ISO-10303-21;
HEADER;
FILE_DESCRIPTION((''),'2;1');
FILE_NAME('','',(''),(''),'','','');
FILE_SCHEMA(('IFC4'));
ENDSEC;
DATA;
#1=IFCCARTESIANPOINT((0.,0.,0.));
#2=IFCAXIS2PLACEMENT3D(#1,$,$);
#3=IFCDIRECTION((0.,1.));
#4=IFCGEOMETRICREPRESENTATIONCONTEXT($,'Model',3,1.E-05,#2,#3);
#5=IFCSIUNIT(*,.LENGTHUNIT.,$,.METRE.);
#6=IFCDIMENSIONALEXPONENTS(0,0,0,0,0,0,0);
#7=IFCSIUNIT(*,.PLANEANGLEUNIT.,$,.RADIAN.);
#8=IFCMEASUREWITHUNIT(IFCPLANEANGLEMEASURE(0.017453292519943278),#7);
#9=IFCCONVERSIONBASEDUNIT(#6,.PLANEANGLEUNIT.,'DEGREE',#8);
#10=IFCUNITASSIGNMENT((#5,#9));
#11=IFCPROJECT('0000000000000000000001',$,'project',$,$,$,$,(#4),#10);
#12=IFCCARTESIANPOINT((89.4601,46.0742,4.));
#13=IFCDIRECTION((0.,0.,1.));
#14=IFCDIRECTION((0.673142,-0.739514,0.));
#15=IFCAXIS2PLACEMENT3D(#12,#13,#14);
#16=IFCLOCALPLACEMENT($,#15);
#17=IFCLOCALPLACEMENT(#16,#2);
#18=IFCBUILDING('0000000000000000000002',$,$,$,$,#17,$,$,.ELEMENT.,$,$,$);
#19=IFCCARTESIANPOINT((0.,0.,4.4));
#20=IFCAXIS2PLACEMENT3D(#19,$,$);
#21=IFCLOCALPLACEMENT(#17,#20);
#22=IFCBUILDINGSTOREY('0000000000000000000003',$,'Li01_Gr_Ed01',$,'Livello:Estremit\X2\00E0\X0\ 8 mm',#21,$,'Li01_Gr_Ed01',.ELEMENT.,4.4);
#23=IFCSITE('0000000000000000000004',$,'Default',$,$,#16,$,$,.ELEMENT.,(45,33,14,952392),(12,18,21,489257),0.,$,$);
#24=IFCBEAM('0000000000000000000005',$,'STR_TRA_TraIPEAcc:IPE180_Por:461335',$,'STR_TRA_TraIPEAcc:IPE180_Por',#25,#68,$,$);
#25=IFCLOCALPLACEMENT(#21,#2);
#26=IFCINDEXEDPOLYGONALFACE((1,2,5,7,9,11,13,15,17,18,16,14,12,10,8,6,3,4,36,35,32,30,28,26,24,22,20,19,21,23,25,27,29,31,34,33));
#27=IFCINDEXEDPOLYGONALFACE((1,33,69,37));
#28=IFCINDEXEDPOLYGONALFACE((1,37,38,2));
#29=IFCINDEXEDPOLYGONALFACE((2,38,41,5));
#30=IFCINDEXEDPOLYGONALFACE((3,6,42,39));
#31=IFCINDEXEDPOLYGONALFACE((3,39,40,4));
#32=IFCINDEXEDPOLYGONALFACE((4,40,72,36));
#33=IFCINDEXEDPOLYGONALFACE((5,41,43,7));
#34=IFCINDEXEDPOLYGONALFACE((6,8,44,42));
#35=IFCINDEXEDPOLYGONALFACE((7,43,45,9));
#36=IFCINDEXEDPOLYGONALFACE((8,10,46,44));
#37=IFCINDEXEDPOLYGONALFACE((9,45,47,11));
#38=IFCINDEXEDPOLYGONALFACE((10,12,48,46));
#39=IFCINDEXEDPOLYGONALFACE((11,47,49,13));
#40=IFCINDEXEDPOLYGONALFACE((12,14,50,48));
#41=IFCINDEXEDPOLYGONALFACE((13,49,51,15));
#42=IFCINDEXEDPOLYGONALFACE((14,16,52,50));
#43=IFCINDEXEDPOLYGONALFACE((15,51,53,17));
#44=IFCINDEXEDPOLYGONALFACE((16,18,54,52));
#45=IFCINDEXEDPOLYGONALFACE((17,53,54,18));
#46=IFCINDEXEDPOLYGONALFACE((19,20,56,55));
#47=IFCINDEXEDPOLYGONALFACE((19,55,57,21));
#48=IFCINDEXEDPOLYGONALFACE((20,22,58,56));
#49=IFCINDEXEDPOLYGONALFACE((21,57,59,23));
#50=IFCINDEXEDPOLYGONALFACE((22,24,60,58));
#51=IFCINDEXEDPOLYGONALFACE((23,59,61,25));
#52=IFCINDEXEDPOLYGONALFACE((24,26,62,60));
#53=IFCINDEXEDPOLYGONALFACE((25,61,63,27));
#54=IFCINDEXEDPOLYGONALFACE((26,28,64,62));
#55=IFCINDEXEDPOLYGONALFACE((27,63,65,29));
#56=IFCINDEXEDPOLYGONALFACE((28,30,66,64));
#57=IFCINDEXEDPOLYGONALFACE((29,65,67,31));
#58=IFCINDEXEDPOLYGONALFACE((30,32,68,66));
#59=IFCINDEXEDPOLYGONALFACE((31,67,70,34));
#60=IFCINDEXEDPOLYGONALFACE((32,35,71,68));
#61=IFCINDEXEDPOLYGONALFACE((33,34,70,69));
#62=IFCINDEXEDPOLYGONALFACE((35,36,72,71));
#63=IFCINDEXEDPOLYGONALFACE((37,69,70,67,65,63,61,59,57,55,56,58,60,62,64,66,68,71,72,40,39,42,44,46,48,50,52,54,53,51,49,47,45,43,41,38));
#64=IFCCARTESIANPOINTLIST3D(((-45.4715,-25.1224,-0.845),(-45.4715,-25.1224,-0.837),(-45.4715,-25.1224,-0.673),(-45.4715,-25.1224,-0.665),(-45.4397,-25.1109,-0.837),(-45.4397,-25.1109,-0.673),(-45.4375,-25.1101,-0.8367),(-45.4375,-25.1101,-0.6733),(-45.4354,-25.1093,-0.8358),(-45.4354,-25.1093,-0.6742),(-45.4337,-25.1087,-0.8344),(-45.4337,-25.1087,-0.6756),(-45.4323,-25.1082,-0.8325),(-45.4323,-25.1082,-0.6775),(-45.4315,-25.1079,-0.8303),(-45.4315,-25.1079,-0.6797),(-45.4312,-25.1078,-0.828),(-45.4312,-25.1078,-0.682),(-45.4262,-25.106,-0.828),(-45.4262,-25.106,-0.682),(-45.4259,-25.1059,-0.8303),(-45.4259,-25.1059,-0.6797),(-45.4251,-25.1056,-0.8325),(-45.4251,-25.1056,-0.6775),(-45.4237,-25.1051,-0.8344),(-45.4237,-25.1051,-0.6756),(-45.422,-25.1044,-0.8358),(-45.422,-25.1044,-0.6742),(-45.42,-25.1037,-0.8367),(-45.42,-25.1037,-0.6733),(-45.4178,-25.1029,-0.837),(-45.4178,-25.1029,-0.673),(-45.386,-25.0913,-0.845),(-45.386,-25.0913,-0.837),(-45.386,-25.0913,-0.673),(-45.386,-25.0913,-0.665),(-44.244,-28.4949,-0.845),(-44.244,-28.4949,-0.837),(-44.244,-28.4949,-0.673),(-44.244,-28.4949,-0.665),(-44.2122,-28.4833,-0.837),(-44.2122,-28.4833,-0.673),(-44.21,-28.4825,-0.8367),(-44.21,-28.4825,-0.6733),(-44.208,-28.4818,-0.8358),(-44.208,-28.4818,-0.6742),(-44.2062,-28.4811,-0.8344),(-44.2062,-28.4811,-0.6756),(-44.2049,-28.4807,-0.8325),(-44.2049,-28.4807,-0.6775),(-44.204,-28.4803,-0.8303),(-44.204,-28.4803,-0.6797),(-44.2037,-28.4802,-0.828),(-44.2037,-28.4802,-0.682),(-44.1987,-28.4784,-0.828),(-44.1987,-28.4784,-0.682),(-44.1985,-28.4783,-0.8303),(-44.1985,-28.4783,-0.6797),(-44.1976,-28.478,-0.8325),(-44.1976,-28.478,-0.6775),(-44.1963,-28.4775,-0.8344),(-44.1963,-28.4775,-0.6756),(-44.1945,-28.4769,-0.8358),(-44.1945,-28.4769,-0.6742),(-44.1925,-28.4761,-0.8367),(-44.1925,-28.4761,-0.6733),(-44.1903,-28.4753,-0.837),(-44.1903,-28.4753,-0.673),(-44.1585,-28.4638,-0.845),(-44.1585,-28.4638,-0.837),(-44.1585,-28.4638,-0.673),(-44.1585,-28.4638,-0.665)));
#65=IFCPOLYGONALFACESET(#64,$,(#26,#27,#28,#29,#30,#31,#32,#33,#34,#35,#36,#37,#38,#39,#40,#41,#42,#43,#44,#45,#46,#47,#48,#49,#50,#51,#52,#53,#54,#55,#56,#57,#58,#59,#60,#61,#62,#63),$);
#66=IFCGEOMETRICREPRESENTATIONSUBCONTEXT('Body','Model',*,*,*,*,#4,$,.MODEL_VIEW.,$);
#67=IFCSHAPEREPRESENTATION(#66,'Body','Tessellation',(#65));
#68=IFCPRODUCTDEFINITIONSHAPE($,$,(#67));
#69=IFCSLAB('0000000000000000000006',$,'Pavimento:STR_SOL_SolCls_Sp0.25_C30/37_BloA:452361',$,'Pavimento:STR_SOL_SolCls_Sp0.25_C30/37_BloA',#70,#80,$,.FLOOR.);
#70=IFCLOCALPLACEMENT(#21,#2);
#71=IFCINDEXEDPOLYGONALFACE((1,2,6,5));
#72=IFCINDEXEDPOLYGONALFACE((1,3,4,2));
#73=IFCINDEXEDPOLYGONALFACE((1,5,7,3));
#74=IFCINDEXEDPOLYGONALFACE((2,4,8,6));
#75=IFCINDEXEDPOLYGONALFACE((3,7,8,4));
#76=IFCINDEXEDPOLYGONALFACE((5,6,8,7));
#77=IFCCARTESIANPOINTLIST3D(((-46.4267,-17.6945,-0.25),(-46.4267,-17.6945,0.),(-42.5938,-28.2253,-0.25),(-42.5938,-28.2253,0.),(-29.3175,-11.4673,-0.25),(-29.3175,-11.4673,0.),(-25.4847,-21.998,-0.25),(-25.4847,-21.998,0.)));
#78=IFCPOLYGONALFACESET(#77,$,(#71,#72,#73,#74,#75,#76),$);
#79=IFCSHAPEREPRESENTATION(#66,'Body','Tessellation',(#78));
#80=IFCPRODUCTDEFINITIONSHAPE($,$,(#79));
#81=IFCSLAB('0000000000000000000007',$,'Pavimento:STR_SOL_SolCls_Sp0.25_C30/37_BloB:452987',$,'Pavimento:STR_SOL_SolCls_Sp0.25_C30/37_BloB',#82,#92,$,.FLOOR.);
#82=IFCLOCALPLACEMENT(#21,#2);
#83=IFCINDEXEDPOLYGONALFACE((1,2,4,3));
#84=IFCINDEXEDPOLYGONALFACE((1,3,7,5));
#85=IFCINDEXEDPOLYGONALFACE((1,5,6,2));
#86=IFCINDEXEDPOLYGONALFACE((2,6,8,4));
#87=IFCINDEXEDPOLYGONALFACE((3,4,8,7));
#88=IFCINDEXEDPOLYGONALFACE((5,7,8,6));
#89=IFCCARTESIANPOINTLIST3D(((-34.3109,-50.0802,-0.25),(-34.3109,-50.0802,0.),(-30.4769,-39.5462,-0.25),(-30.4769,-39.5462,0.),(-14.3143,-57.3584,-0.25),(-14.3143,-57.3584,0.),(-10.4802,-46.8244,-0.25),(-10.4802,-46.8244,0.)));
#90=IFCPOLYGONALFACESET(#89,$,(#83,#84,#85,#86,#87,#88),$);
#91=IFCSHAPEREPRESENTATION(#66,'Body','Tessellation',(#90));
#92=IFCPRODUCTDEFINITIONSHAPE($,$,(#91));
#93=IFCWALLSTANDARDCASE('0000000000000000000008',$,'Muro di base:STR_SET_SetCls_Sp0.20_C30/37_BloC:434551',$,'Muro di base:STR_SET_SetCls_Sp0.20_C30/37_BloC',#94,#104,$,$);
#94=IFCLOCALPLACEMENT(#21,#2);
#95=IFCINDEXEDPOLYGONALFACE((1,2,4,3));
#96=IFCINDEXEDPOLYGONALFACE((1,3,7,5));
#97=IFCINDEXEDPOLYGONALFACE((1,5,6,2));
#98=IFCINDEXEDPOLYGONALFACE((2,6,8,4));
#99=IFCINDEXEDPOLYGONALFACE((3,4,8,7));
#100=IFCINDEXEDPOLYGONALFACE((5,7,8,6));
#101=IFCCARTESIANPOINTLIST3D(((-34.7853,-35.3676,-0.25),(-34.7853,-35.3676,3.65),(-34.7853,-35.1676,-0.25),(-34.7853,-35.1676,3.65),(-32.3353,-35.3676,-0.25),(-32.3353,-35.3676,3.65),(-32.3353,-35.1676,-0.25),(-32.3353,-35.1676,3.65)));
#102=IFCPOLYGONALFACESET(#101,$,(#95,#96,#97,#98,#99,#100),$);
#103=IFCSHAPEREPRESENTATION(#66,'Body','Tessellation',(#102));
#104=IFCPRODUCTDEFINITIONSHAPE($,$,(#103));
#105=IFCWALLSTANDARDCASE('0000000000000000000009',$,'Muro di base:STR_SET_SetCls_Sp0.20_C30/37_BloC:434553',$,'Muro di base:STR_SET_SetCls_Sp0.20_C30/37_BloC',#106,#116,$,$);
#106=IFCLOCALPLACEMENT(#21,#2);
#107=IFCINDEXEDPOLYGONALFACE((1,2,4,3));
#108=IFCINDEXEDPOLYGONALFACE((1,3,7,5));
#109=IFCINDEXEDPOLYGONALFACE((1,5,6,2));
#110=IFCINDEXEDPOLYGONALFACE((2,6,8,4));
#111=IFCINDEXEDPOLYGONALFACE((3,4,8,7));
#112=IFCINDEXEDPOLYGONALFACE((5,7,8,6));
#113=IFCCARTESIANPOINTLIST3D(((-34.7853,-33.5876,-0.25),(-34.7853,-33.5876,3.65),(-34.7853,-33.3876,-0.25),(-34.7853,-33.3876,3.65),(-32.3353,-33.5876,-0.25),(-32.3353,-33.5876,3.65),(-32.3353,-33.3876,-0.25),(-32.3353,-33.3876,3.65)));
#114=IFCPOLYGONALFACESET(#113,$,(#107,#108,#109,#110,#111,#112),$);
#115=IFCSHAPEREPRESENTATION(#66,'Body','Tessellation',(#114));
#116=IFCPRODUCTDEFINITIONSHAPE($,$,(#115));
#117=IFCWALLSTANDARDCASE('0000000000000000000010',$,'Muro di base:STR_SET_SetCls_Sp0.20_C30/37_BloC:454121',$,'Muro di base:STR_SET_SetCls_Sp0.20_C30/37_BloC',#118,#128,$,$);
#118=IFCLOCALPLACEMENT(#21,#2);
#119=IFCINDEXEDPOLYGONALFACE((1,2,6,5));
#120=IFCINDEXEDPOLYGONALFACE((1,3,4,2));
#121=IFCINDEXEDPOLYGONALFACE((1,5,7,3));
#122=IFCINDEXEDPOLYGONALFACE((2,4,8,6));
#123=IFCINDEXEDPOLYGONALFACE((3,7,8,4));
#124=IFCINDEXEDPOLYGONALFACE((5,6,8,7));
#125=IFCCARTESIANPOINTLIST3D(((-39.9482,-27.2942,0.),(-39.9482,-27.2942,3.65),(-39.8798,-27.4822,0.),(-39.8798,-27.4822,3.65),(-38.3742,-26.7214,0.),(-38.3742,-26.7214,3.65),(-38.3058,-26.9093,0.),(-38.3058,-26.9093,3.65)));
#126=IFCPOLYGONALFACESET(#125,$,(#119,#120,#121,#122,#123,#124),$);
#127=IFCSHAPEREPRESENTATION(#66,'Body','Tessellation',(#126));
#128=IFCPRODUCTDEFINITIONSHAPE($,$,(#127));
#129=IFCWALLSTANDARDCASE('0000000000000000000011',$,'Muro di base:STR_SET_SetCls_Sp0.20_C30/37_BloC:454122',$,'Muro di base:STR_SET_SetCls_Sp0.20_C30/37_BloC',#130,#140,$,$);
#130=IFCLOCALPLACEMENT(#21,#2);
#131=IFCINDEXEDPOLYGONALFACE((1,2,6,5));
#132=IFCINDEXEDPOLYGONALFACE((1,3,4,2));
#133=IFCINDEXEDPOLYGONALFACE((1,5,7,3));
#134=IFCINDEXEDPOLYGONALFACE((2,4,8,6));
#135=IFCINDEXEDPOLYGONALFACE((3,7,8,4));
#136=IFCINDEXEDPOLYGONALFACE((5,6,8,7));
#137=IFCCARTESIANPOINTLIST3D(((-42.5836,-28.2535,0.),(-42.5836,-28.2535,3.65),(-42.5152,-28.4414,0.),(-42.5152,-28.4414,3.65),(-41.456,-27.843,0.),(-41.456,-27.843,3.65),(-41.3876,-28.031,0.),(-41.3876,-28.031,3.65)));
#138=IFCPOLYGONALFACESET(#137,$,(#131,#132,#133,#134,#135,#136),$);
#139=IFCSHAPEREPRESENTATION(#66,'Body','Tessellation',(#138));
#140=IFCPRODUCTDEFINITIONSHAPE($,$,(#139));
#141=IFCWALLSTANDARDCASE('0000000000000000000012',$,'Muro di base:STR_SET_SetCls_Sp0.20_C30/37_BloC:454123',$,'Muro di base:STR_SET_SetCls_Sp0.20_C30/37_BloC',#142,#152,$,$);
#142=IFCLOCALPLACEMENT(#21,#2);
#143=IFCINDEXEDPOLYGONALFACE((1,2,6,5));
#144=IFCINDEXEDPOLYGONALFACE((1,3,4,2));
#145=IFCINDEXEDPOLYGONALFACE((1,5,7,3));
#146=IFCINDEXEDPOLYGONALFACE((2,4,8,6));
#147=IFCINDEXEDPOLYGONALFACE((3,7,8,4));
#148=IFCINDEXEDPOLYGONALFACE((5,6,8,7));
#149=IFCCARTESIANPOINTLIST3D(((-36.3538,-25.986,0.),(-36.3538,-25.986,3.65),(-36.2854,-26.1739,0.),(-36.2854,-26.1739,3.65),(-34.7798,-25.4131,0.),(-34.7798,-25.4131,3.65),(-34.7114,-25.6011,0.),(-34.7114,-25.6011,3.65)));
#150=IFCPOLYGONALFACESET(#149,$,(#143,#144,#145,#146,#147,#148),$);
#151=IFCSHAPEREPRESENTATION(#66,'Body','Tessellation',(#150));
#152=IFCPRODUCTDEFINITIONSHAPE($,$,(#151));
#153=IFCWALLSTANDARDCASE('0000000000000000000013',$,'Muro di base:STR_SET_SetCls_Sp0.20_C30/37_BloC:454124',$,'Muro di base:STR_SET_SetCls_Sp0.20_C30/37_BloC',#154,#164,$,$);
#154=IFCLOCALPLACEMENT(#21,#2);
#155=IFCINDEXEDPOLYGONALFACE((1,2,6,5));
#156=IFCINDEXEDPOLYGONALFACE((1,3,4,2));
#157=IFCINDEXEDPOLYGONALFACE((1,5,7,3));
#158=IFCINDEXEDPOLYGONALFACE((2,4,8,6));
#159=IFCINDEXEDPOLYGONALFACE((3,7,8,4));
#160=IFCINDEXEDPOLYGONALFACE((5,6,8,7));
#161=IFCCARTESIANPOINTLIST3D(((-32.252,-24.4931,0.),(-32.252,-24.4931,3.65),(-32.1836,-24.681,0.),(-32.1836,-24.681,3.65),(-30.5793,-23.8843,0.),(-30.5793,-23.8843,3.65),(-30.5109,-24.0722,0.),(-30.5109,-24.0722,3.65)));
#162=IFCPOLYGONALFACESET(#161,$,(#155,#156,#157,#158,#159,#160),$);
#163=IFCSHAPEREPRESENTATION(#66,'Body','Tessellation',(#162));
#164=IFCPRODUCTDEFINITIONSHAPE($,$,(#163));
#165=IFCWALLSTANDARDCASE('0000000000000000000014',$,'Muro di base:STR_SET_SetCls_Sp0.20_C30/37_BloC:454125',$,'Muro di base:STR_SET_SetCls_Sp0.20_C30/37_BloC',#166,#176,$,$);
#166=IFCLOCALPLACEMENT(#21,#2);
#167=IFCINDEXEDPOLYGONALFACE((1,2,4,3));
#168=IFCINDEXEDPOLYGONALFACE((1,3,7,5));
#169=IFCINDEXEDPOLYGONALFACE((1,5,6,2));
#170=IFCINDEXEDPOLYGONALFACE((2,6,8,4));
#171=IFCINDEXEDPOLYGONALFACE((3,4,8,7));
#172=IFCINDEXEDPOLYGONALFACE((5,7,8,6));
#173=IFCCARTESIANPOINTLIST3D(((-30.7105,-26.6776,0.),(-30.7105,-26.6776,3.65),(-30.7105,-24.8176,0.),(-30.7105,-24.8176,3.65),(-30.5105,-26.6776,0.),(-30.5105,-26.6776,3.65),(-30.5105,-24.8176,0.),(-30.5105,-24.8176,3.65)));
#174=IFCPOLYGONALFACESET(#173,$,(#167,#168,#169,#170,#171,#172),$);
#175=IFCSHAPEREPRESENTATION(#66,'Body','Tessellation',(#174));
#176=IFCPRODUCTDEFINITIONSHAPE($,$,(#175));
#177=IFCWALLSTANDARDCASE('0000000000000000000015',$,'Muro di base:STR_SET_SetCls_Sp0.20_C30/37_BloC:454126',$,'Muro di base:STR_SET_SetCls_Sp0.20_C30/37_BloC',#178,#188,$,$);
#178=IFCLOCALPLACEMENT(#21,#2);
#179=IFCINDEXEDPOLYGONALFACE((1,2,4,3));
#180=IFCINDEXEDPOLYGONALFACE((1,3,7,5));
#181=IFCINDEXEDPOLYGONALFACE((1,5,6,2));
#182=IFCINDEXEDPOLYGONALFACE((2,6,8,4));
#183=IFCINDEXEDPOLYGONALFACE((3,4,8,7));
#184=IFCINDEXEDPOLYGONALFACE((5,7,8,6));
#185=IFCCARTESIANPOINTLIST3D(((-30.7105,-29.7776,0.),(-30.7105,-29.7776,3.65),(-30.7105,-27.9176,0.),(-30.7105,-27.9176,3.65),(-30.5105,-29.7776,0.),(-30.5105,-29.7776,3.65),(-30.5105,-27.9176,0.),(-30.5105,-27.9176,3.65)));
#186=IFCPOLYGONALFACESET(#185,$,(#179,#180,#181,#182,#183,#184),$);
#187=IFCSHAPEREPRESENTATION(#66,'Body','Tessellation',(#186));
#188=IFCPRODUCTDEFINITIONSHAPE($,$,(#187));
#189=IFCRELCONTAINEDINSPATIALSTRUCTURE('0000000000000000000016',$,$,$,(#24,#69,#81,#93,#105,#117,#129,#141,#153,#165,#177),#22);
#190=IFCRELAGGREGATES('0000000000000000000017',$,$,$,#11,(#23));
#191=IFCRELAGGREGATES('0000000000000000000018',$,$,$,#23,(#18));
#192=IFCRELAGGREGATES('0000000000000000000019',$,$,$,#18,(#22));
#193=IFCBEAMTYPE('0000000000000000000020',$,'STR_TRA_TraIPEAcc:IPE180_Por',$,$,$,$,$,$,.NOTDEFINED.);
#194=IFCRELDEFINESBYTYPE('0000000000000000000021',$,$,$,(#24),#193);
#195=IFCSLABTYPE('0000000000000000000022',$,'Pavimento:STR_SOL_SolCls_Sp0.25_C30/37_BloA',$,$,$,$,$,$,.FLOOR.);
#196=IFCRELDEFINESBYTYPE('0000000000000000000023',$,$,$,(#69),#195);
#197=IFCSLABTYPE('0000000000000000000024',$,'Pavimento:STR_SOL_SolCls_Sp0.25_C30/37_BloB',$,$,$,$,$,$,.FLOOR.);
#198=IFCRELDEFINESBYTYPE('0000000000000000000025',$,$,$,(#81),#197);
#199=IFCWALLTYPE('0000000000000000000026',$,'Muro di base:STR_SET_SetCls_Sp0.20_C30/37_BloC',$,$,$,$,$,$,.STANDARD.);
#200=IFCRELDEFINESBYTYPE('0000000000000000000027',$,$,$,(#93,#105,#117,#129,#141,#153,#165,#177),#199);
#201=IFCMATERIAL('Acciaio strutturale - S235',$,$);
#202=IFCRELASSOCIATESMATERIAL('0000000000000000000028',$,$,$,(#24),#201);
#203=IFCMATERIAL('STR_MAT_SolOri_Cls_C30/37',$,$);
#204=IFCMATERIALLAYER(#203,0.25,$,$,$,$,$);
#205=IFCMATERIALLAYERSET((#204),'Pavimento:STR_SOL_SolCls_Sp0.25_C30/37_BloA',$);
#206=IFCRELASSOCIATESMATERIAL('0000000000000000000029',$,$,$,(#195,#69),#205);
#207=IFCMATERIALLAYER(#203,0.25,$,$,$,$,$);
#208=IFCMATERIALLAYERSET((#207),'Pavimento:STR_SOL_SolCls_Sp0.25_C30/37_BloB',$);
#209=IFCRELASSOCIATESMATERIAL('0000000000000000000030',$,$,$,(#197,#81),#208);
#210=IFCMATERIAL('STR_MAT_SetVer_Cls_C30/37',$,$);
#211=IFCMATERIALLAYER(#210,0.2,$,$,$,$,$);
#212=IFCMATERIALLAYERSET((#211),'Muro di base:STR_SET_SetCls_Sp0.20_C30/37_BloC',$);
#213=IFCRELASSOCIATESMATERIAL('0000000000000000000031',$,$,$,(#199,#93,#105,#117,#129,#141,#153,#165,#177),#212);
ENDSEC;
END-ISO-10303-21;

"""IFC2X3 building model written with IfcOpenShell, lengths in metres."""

from ifc_helpers import new_model, entity, si_unit, converted_unit, direction, frame, frame_2d, origin, place, context, subcontext, project, spatial, polyline, rectangle, i_section, outline, extrude, material, layer, layer_set, layer_usage, type_object, element, save


model = new_model("IFC2X3")

# Units and contexts
model_context = context("Model", 3, precision=1e-05, world=origin(), true_north=direction((0.0, 1.0)))
body_context = subcontext(model_context, "Body", "Model", "MODEL_VIEW")
ifc_project = project(units=[si_unit("LENGTHUNIT", "METRE"), converted_unit("PLANEANGLEUNIT", "DEGREE", entity("IfcPlaneAngleMeasure", 0.017453292519943278), si_unit("PLANEANGLEUNIT", "RADIAN"), dimensions=[0, 0, 0, 0, 0, 0, 0])], contexts=[model_context])

# Site, building, storey
site_placement = place(None, frame((89.4601, 46.0742, 4.0), z_axis=(0.0, 0.0, 1.0), x_axis=(0.673142, -0.739514, 0.0)))
site = spatial("IfcSite", under=ifc_project, at=site_placement, Name="Default", CompositionType="ELEMENT", RefLatitude=(45, 33, 14, 952392), RefLongitude=(12, 18, 21, 489257), RefElevation=0.0)
building_placement = place(site_placement, origin())
building = spatial("IfcBuilding", under=site, at=building_placement, CompositionType="ELEMENT")
storey_placement = place(building_placement, frame((0.0, 0.0, 4.4)))
storey = spatial("IfcBuildingStorey", under=building, at=storey_placement, Name="Li01_Gr_Ed01", ObjectType="Livello:Estremità 8 mm", LongName="Li01_Gr_Ed01", CompositionType="ELEMENT", Elevation=4.4)

# Beam
ifc_material_1 = material(Name="Acciaio strutturale - S235")
beam_type = type_object("IfcBeamType", Name="STR_TRA_TraIPEAcc:IPE180_Por", PredefinedType="NOTDEFINED")
beam_1_placement = place(storey_placement, frame((-45.4812, -24.9627, -0.665), z_axis=(0.0, 0.0, 1.0), x_axis=(0.34202, -0.939693, 0.0)))
element("IfcBeam", 1, at=beam_1_placement, inside=storey, type_object=beam_type, material=ifc_material_1, Name="STR_TRA_TraIPEAcc:IPE180_Por:461335", ObjectType="STR_TRA_TraIPEAcc:IPE180_Por", context=body_context, shape_type="SweptSolid", body=[
    extrude(i_section(OverallWidth=0.091, OverallDepth=0.18, WebThickness=0.0053, FlangeThickness=0.008, FilletRadius=0.009, at=frame_2d((0.0, 0.0), x_axis=(0.0, 1.0))), frame((0.1534, 0.0, -0.09), z_axis=(1.0, 0.0, 0.0), x_axis=(0.0, 0.0, -1.0)), (0.0, 0.0, 1.0), 3.5889),
])

# Slabs
ifc_material_2 = material(Name="STR_MAT_SolOri_Cls_C30/37")
ifc_layer_1 = layer(ifc_material_2, 0.25)
ifc_layer_set_1 = layer_set([ifc_layer_1], Name="Pavimento:STR_SOL_SolCls_Sp0.25_C30/37_BloA")
ifc_layer_usage_1 = layer_usage(ifc_layer_set_1, "AXIS3", "POSITIVE", 0.0)
slab_type_1 = type_object("IfcSlabType", Name="Pavimento:STR_SOL_SolCls_Sp0.25_C30/37_BloA", PredefinedType="FLOOR", material=ifc_layer_set_1)
slab_1_placement = place(storey_placement, origin())
element("IfcSlab", 2, at=slab_1_placement, inside=storey, type_object=slab_type_1, material=ifc_layer_usage_1, Name="Pavimento:STR_SOL_SolCls_Sp0.25_C30/37_BloA:452361", ObjectType="Pavimento:STR_SOL_SolCls_Sp0.25_C30/37_BloA", PredefinedType="FLOOR", context=body_context, shape_type="SweptSolid", body=[
    extrude(rectangle(XDim=18.2072, YDim=11.2066, at=frame_2d((0.0, 0.0), x_axis=(1.0, 0.0))), frame((-35.9557, -19.8463, 0.0), z_axis=(0.0, 0.0, -1.0), x_axis=(0.939693, 0.34202, 0.0)), (0.0, 0.0, 1.0), 0.25),
])
ifc_layer_2 = layer(ifc_material_2, 0.25)
ifc_layer_set_2 = layer_set([ifc_layer_2], Name="Pavimento:STR_SOL_SolCls_Sp0.25_C30/37_BloB")
ifc_layer_usage_2 = layer_usage(ifc_layer_set_2, "AXIS3", "POSITIVE", 0.0)
slab_type_2 = type_object("IfcSlabType", Name="Pavimento:STR_SOL_SolCls_Sp0.25_C30/37_BloB", PredefinedType="FLOOR", material=ifc_layer_set_2)
slab_2_placement = place(storey_placement, origin())
element("IfcSlab", 3, at=slab_2_placement, inside=storey, type_object=slab_type_2, material=ifc_layer_usage_2, Name="Pavimento:STR_SOL_SolCls_Sp0.25_C30/37_BloB:452987", ObjectType="Pavimento:STR_SOL_SolCls_Sp0.25_C30/37_BloB", PredefinedType="FLOOR", context=body_context, shape_type="SweptSolid", body=[
    extrude(outline(polyline([(-10.64, -5.605), (10.64, -5.605), (10.64, 5.605), (-10.64, 5.605), (-10.64, -5.605)])), frame((-22.3956, -48.4523, 0.0), z_axis=(0.0, 0.0, -1.0), x_axis=(0.939693, -0.34202, 0.0)), (0.0, 0.0, 1.0), 0.25),
])

# Walls
ifc_material_3 = material(Name="STR_MAT_SetVer_Cls_C30/37")
ifc_layer_3 = layer(ifc_material_3, 0.2)
ifc_layer_set_3 = layer_set([ifc_layer_3], Name="Muro di base:STR_SET_SetCls_Sp0.20_C30/37_BloC")
ifc_layer_usage_3 = layer_usage(ifc_layer_set_3, "AXIS2", "NEGATIVE", 0.1)
wall_type = type_object("IfcWallType", Name="Muro di base:STR_SET_SetCls_Sp0.20_C30/37_BloC", PredefinedType="STANDARD", material=ifc_layer_set_3)
wall_1_placement = place(storey_placement, frame((-34.7853, -35.2676, -0.25)))
element("IfcWallStandardCase", 4, at=wall_1_placement, inside=storey, type_object=wall_type, material=ifc_layer_usage_3, Name="Muro di base:STR_SET_SetCls_Sp0.20_C30/37_BloC:434551", ObjectType="Muro di base:STR_SET_SetCls_Sp0.20_C30/37_BloC", context=body_context, shape_type="SweptSolid", body=[
    extrude(rectangle(XDim=2.45, YDim=0.2, at=frame_2d((1.225, 0.0), x_axis=(-1.0, 0.0))), origin(), (0.0, 0.0, 1.0), 3.9),
])
wall_2_placement = place(storey_placement, frame((-32.3353, -33.4876, -0.25), z_axis=(0.0, 0.0, 1.0), x_axis=(-1.0, 0.0, 0.0)))
element("IfcWallStandardCase", 5, at=wall_2_placement, inside=storey, type_object=wall_type, material=ifc_layer_usage_3, Name="Muro di base:STR_SET_SetCls_Sp0.20_C30/37_BloC:434553", ObjectType="Muro di base:STR_SET_SetCls_Sp0.20_C30/37_BloC", context=body_context, shape_type="SweptSolid", body=[
    extrude(rectangle(XDim=2.45, YDim=0.2, at=frame_2d((1.225, 0.0), x_axis=(-1.0, 0.0))), origin(), (0.0, 0.0, 1.0), 3.9),
])
wall_3_placement = place(storey_placement, frame((-39.914, -27.3882, 0.0), z_axis=(0.0, 0.0, 1.0), x_axis=(0.939693, 0.34202, 0.0)))
element("IfcWallStandardCase", 6, at=wall_3_placement, inside=storey, type_object=wall_type, material=ifc_layer_usage_3, Name="Muro di base:STR_SET_SetCls_Sp0.20_C30/37_BloC:454121", ObjectType="Muro di base:STR_SET_SetCls_Sp0.20_C30/37_BloC", context=body_context, shape_type="SweptSolid", body=[
    extrude(rectangle(XDim=1.675, YDim=0.2, at=frame_2d((0.8375, 0.0), x_axis=(-1.0, 0.0))), origin(), (0.0, 0.0, 1.0), 3.65),
])
wall_4_placement = place(storey_placement, frame((-42.5494, -28.3474, 0.0), z_axis=(0.0, 0.0, 1.0), x_axis=(0.939693, 0.34202, 0.0)))
element("IfcWallStandardCase", 7, at=wall_4_placement, inside=storey, type_object=wall_type, material=ifc_layer_usage_3, Name="Muro di base:STR_SET_SetCls_Sp0.20_C30/37_BloC:454122", ObjectType="Muro di base:STR_SET_SetCls_Sp0.20_C30/37_BloC", context=body_context, shape_type="SweptSolid", body=[
    extrude(rectangle(XDim=1.2, YDim=0.2, at=frame_2d((0.6, 0.0), x_axis=(-1.0, 0.0))), origin(), (0.0, 0.0, 1.0), 3.65),
])
wall_5_placement = place(storey_placement, frame((-36.3196, -26.08, 0.0), z_axis=(0.0, 0.0, 1.0), x_axis=(0.939693, 0.34202, 0.0)))
element("IfcWallStandardCase", 8, at=wall_5_placement, inside=storey, type_object=wall_type, material=ifc_layer_usage_3, Name="Muro di base:STR_SET_SetCls_Sp0.20_C30/37_BloC:454123", ObjectType="Muro di base:STR_SET_SetCls_Sp0.20_C30/37_BloC", context=body_context, shape_type="SweptSolid", body=[
    extrude(rectangle(XDim=1.675, YDim=0.2, at=frame_2d((0.8375, 0.0), x_axis=(-1.0, 0.0))), origin(), (0.0, 0.0, 1.0), 3.65),
])
wall_6_placement = place(storey_placement, frame((-32.2178, -24.587, 0.0), z_axis=(0.0, 0.0, 1.0), x_axis=(0.939693, 0.34202, 0.0)))
element("IfcWallStandardCase", 9, at=wall_6_placement, inside=storey, type_object=wall_type, material=ifc_layer_usage_3, Name="Muro di base:STR_SET_SetCls_Sp0.20_C30/37_BloC:454124", ObjectType="Muro di base:STR_SET_SetCls_Sp0.20_C30/37_BloC", context=body_context, shape_type="SweptSolid", body=[
    extrude(rectangle(XDim=1.78, YDim=0.2, at=frame_2d((0.89, 0.0), x_axis=(-1.0, 0.0))), origin(), (0.0, 0.0, 1.0), 3.65),
])
wall_7_placement = place(storey_placement, frame((-30.6105, -24.8176, 0.0), z_axis=(0.0, 0.0, 1.0), x_axis=(0.0, -1.0, 0.0)))
element("IfcWallStandardCase", 10, at=wall_7_placement, inside=storey, type_object=wall_type, material=ifc_layer_usage_3, Name="Muro di base:STR_SET_SetCls_Sp0.20_C30/37_BloC:454125", ObjectType="Muro di base:STR_SET_SetCls_Sp0.20_C30/37_BloC", context=body_context, shape_type="SweptSolid", body=[
    extrude(rectangle(XDim=1.86, YDim=0.2, at=frame_2d((0.93, 0.0), x_axis=(-1.0, 0.0))), origin(), (0.0, 0.0, 1.0), 3.65),
])
wall_8_placement = place(storey_placement, frame((-30.6105, -27.9176, 0.0), z_axis=(0.0, 0.0, 1.0), x_axis=(0.0, -1.0, 0.0)))
element("IfcWallStandardCase", 11, at=wall_8_placement, inside=storey, type_object=wall_type, material=ifc_layer_usage_3, Name="Muro di base:STR_SET_SetCls_Sp0.20_C30/37_BloC:454126", ObjectType="Muro di base:STR_SET_SetCls_Sp0.20_C30/37_BloC", context=body_context, shape_type="SweptSolid", body=[
    extrude(rectangle(XDim=1.86, YDim=0.2, at=frame_2d((0.93, 0.0), x_axis=(-1.0, 0.0))), origin(), (0.0, 0.0, 1.0), 3.65),
])

save(model, "model.ifc")
